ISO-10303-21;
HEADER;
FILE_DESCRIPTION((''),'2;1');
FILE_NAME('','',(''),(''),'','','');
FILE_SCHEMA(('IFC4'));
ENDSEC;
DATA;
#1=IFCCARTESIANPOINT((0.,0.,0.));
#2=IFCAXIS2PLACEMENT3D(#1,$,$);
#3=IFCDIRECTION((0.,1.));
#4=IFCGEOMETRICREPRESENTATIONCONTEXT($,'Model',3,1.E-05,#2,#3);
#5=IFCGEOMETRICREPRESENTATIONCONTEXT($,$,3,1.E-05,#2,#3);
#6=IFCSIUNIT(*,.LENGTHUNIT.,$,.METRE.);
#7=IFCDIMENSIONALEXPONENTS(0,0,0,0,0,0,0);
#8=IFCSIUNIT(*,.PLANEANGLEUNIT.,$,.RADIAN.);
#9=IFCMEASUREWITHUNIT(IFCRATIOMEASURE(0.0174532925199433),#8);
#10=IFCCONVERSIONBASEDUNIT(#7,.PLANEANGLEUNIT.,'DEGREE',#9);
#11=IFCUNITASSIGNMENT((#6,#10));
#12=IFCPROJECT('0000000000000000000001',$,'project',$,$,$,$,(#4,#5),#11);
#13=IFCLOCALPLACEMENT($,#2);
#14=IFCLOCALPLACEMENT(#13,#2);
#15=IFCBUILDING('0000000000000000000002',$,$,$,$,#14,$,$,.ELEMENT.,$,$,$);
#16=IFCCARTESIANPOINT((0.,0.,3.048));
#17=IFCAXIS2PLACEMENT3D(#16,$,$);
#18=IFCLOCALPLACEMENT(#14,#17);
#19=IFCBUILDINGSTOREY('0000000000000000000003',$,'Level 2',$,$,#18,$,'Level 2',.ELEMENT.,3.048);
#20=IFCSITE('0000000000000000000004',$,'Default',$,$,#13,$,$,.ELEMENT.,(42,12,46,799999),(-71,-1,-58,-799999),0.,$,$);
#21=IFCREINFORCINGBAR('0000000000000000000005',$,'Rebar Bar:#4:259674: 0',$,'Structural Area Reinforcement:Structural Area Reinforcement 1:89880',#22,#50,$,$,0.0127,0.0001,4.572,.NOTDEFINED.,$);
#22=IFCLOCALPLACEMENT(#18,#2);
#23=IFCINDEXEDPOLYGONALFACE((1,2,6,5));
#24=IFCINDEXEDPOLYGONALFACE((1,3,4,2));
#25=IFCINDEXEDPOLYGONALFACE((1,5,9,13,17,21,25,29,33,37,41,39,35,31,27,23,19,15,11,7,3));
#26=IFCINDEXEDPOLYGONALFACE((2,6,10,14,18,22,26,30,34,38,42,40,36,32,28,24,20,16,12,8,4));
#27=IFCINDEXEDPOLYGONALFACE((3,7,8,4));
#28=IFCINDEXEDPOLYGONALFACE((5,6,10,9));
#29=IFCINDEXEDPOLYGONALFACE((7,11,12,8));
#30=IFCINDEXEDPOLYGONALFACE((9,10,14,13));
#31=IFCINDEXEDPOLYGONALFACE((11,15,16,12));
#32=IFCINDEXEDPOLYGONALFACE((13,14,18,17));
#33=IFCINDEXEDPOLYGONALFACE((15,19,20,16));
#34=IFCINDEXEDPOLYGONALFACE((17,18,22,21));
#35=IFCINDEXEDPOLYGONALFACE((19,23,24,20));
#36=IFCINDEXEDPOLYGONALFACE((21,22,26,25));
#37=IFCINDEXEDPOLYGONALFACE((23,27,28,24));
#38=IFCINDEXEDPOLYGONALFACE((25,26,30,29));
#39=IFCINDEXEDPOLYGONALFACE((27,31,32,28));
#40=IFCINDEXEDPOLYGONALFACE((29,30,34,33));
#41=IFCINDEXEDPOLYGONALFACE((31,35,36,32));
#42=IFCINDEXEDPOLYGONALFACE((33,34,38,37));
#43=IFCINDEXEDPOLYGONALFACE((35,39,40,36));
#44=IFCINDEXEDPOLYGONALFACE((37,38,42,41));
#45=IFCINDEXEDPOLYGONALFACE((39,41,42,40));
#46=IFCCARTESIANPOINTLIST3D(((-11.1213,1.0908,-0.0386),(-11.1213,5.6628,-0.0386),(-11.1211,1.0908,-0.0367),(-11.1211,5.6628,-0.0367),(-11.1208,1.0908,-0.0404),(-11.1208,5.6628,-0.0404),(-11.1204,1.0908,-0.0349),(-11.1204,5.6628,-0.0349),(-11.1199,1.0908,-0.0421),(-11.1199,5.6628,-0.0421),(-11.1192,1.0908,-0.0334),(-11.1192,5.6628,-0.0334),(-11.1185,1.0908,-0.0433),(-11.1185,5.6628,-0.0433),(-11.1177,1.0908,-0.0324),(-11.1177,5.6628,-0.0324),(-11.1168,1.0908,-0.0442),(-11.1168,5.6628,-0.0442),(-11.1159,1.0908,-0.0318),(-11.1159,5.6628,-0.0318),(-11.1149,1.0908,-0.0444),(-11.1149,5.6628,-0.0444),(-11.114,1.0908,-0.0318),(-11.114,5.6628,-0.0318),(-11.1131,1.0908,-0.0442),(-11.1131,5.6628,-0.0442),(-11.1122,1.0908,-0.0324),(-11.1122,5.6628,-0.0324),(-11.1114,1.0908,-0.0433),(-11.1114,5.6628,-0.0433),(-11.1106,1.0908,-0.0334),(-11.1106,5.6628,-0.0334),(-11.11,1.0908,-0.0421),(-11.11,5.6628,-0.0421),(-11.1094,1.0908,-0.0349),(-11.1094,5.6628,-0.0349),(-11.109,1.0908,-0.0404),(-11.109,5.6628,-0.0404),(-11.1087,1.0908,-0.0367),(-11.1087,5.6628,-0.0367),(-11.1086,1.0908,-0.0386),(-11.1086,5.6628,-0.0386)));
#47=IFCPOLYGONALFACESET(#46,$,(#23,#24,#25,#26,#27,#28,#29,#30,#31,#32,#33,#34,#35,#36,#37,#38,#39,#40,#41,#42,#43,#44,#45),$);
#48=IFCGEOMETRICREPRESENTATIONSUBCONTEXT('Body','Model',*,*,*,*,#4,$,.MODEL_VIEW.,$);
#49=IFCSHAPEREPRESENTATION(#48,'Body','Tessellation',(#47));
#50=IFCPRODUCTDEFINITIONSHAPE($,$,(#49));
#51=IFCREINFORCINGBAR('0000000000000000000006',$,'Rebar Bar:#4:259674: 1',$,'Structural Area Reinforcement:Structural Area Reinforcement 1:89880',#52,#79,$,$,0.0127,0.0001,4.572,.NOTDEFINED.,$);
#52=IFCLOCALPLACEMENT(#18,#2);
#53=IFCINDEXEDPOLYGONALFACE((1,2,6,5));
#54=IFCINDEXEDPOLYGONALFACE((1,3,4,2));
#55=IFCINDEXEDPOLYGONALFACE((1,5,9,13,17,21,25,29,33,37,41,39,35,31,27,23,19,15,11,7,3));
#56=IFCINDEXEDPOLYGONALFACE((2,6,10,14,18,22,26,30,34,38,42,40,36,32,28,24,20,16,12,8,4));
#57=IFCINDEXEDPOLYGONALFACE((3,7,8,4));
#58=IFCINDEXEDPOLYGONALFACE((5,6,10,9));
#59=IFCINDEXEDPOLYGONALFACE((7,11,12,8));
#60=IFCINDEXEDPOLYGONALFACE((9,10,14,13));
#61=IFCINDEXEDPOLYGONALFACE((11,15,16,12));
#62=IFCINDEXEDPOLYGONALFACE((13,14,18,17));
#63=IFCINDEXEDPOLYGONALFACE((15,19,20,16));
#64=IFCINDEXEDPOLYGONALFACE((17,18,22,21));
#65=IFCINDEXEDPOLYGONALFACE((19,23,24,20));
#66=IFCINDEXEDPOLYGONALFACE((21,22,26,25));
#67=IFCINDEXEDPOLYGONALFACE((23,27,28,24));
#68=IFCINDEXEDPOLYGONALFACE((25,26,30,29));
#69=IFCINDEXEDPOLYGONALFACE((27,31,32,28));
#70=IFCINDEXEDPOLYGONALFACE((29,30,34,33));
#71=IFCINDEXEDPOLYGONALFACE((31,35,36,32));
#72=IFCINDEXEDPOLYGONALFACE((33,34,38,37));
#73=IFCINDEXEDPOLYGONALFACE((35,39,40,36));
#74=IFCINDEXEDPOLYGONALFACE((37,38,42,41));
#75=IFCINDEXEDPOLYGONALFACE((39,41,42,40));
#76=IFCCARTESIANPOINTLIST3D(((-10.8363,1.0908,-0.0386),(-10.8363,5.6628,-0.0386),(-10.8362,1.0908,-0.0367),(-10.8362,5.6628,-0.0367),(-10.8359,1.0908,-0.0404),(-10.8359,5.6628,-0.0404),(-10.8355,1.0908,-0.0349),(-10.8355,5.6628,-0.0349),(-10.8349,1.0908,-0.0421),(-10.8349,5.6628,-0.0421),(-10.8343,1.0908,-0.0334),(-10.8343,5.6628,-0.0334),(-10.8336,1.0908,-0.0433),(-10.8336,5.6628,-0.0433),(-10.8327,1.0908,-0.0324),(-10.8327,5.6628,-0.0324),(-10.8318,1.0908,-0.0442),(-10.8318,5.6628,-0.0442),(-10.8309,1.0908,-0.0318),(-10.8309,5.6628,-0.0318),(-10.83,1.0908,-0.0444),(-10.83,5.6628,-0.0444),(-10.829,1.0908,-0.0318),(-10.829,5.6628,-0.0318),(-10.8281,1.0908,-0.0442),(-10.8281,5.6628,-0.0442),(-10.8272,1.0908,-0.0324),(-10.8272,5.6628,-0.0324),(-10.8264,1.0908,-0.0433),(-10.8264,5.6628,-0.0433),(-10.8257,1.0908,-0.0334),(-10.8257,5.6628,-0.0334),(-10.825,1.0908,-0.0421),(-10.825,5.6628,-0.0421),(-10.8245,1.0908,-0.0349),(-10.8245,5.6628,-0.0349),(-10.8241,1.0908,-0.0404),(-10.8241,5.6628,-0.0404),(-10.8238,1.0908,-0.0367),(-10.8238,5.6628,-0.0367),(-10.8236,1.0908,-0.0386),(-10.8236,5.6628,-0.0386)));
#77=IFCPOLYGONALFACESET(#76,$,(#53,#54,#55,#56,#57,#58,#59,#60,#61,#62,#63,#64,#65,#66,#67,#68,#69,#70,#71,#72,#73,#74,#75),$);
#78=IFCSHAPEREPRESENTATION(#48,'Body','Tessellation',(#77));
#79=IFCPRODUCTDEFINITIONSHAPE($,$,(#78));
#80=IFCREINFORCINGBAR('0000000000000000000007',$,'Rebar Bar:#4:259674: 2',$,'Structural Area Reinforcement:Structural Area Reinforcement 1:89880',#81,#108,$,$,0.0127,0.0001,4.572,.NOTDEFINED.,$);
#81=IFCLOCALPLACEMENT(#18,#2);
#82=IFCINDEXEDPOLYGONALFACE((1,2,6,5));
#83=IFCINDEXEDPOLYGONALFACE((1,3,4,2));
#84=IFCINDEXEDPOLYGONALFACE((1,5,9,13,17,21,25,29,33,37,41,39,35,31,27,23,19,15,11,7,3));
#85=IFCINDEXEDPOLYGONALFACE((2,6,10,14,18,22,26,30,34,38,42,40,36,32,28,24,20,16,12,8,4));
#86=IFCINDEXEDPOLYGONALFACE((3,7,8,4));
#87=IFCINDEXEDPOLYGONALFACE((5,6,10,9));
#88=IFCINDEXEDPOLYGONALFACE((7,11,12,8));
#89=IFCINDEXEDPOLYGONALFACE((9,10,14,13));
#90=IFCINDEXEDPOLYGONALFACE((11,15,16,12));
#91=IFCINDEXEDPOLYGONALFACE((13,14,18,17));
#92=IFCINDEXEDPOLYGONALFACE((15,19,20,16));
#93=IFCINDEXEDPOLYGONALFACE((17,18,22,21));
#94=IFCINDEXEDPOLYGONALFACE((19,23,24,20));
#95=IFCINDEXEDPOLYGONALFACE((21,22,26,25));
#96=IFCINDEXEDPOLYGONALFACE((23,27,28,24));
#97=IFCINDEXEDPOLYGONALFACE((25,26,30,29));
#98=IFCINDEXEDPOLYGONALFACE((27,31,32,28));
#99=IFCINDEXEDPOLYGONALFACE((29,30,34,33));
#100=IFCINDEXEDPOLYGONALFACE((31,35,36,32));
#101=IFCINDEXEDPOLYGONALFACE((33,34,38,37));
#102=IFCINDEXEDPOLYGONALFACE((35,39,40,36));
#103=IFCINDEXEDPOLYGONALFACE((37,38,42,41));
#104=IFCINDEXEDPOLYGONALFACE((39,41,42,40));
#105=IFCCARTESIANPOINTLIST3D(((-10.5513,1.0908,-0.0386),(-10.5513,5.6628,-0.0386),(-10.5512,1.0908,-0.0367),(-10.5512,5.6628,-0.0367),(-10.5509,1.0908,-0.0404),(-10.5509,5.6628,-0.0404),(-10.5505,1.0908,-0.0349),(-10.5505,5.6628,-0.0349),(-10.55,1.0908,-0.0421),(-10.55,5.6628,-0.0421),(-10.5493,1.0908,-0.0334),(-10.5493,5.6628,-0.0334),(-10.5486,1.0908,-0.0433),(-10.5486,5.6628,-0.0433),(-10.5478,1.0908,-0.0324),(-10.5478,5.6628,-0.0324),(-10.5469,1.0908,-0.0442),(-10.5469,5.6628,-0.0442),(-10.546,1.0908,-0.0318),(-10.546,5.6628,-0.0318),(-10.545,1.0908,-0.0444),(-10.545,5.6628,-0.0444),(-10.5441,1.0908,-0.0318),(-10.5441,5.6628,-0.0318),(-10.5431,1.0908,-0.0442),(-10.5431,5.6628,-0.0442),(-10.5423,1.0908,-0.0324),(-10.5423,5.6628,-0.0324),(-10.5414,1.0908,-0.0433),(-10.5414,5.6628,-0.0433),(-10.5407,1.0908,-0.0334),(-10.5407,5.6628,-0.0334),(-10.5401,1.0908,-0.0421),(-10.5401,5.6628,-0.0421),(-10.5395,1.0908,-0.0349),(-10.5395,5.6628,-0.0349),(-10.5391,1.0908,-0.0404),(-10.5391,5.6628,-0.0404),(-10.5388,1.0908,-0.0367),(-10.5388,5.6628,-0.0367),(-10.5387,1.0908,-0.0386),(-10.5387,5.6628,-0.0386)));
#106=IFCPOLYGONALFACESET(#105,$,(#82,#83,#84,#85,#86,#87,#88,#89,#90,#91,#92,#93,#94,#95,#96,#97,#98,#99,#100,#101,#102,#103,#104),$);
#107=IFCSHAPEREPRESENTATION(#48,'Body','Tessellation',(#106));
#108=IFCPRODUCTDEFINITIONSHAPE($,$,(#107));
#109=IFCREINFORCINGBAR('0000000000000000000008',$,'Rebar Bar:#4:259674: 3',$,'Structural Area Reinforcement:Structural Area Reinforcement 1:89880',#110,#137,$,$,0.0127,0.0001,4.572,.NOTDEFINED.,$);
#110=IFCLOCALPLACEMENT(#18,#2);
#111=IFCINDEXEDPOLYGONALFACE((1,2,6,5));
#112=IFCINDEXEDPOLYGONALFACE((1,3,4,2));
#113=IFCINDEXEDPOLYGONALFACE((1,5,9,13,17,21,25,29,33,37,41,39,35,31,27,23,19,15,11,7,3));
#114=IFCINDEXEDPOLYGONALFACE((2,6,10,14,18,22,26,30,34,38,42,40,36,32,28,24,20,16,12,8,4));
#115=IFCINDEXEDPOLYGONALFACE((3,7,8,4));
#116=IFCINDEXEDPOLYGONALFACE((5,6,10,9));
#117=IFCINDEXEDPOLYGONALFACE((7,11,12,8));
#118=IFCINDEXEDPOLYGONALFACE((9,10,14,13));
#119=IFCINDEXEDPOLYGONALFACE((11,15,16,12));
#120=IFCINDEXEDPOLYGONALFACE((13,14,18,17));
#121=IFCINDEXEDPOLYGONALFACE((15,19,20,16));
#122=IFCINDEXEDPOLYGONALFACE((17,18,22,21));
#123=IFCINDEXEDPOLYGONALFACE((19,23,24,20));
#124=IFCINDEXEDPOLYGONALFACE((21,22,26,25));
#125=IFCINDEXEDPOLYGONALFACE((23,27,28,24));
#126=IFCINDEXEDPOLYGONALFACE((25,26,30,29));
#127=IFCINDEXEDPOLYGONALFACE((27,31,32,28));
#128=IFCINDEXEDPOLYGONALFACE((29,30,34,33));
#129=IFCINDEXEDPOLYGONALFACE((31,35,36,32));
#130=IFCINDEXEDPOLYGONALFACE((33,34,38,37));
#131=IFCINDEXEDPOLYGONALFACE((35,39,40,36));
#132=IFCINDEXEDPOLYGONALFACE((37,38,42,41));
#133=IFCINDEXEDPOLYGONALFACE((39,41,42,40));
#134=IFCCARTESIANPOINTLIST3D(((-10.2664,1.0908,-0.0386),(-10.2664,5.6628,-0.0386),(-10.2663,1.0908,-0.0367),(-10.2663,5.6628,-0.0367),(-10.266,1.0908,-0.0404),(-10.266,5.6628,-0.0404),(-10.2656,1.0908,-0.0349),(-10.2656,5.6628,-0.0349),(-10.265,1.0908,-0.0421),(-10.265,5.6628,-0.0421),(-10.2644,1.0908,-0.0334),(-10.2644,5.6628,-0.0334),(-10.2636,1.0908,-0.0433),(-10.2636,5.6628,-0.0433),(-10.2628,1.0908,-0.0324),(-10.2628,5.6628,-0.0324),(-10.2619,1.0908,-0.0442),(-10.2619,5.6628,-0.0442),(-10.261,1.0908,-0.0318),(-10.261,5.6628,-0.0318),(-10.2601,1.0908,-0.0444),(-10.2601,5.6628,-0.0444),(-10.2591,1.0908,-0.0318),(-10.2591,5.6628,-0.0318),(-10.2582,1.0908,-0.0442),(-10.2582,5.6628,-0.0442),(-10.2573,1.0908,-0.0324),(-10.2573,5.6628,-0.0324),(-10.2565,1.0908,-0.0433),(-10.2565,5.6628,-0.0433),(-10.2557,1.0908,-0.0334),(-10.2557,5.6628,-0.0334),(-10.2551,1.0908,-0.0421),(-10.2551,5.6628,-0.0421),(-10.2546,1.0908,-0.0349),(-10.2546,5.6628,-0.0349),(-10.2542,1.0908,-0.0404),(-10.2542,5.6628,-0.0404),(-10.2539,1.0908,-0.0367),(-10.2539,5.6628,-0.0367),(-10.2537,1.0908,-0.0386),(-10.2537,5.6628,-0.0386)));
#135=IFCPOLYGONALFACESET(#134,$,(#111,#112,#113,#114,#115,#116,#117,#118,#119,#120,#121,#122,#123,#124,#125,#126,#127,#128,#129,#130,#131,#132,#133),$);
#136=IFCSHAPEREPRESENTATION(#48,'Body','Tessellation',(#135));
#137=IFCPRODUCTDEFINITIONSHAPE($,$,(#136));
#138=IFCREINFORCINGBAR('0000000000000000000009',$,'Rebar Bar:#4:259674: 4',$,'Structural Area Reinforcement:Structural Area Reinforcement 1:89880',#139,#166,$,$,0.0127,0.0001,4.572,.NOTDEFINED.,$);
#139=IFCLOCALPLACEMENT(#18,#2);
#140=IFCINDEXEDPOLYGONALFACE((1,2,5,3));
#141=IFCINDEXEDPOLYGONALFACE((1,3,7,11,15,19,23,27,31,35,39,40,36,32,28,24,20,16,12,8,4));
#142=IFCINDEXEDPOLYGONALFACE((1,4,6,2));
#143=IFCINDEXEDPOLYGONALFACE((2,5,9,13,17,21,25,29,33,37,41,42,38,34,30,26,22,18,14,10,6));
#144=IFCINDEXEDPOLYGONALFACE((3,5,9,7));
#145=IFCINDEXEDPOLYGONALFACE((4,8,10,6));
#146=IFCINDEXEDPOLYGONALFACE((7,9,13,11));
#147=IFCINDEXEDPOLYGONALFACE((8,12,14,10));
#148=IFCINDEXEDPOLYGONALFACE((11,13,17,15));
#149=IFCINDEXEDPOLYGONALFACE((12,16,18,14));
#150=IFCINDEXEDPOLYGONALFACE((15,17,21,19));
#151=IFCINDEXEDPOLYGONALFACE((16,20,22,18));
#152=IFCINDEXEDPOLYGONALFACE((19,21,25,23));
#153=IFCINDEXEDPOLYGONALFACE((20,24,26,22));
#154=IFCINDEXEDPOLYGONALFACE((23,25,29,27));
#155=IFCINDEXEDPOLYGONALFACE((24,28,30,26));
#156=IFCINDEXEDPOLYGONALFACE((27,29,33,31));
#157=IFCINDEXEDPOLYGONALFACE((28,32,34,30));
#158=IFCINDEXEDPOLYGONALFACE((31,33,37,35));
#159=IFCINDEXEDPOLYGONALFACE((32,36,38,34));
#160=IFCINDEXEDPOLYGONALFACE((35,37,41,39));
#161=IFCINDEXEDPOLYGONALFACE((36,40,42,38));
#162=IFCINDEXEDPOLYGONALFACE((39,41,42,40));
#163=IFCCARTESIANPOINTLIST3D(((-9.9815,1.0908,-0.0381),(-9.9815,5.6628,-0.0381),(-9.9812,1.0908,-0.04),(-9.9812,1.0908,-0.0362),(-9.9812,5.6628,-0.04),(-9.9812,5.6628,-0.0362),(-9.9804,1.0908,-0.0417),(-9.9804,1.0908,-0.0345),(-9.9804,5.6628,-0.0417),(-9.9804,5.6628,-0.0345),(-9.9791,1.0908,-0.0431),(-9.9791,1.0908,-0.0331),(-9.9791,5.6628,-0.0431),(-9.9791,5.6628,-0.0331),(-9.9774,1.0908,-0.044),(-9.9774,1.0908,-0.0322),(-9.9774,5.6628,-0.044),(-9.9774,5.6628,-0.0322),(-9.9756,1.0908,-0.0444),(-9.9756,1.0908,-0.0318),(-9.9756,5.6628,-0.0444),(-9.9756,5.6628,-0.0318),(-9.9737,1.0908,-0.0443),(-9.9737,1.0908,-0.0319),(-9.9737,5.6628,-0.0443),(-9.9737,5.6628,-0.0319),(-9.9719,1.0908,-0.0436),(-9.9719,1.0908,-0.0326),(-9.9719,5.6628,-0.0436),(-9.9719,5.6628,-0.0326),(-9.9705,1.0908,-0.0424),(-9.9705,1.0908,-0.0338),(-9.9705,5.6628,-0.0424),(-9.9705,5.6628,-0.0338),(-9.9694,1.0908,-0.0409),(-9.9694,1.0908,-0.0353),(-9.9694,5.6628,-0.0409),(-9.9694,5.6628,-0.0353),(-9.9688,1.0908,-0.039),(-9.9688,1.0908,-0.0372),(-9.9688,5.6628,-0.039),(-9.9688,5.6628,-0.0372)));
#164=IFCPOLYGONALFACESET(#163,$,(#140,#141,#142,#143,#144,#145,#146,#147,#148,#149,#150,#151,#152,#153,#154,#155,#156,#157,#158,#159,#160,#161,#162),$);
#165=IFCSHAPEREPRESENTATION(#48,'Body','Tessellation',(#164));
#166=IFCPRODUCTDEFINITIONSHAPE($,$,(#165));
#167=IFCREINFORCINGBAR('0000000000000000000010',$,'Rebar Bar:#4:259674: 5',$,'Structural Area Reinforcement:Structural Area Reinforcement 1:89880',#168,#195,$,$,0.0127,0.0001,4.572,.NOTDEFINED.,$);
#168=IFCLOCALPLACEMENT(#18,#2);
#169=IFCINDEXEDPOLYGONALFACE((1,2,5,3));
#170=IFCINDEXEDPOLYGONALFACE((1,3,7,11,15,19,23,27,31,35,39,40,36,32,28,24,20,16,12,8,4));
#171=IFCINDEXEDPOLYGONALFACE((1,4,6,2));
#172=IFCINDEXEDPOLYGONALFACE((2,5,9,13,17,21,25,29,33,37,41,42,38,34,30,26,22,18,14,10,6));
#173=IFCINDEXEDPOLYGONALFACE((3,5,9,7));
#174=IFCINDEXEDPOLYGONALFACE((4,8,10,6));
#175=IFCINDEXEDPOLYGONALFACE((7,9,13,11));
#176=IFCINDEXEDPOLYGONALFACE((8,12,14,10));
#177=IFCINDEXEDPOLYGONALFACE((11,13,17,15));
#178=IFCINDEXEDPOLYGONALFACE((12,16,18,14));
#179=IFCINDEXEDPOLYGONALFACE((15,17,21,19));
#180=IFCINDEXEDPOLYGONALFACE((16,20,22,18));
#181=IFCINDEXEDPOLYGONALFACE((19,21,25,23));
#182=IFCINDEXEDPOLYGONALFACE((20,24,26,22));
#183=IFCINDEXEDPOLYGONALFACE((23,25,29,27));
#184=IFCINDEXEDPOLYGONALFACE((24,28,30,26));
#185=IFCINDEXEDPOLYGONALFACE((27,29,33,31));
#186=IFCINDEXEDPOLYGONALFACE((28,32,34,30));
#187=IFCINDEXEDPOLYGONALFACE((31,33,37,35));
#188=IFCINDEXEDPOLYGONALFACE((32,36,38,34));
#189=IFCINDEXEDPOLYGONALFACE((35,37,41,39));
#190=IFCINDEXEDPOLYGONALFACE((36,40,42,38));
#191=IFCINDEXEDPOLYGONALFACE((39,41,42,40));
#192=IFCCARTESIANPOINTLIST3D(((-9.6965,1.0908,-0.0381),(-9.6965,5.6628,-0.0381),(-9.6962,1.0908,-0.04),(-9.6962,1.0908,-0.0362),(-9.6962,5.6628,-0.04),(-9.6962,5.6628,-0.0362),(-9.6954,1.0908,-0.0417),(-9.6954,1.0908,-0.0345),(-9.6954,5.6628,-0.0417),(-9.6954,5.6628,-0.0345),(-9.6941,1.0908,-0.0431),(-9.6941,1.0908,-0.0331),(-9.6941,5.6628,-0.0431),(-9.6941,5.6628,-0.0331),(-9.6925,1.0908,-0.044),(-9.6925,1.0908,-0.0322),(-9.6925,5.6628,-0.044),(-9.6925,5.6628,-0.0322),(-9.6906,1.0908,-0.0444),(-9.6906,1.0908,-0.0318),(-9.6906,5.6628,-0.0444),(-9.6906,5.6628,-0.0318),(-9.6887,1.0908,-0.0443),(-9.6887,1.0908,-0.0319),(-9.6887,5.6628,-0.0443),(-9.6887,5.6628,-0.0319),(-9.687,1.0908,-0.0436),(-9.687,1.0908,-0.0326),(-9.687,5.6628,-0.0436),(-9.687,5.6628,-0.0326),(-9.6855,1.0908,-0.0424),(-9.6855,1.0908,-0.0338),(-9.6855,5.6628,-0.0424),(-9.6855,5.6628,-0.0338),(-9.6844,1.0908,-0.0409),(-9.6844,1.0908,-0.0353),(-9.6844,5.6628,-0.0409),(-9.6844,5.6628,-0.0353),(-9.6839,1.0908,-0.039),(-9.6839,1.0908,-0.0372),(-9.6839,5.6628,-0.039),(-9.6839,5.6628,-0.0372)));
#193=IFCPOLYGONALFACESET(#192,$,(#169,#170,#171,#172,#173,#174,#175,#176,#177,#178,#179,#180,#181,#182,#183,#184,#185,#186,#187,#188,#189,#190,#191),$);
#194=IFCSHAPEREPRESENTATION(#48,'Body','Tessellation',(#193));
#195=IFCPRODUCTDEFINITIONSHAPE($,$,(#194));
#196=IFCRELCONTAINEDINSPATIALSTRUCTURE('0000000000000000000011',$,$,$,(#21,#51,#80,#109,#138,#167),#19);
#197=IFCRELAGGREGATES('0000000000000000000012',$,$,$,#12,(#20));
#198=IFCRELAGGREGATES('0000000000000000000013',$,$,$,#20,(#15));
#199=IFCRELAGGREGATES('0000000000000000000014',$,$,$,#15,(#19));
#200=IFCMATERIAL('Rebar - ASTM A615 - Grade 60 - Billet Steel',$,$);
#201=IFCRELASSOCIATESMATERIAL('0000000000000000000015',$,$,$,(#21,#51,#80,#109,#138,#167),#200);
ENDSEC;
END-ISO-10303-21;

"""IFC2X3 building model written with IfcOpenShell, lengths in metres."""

from ifc_helpers import new_model, entity, si_unit, converted_unit, direction, frame, origin, place, context, subcontext, project, spatial, material, element, save


model = new_model("IFC2X3")

# Units and contexts
model_context = context("Model", 3, precision=1e-05, world=origin(), true_north=direction((0.0, 1.0)))
context_of_model = context(None, 3, precision=1e-05, world=origin(), true_north=direction((0.0, 1.0)))
body_context = subcontext(model_context, "Body", "Model", "MODEL_VIEW")
ifc_project = project(units=[si_unit("LENGTHUNIT", "METRE"), converted_unit("PLANEANGLEUNIT", "DEGREE", entity("IfcRatioMeasure", 0.0174532925199433), si_unit("PLANEANGLEUNIT", "RADIAN"), dimensions=[0, 0, 0, 0, 0, 0, 0])], contexts=[model_context, context_of_model])

# Site, building, storey
site_placement = place(None, origin())
site = spatial("IfcSite", under=ifc_project, at=site_placement, Name="Default", CompositionType="ELEMENT", RefLatitude=(42, 12, 46, 799999), RefLongitude=(-71, -1, -58, -799999), RefElevation=0.0)
building_placement = place(site_placement, origin())
building = spatial("IfcBuilding", under=site, at=building_placement, CompositionType="ELEMENT")
storey_placement = place(building_placement, frame((0.0, 0.0, 3.048)))
storey = spatial("IfcBuildingStorey", under=building, at=storey_placement, Name="Level 2", LongName="Level 2", CompositionType="ELEMENT", Elevation=3.048)

# Reinforcing bars
ifc_material_1 = material(Name="Rebar - ASTM A615 - Grade 60 - Billet Steel")
reinforcing_bar_1_placement = place(storey_placement, origin())
element("IfcReinforcingBar", 1, at=reinforcing_bar_1_placement, inside=storey, material=ifc_material_1, Name="Rebar Bar:#4:259674: 0", ObjectType="Structural Area Reinforcement:Structural Area Reinforcement 1:89880", BarLength=4.572, BarRole="NOTDEFINED", CrossSectionArea=0.0001, NominalDiameter=0.0127, context=body_context, shape_type="AdvancedSweptSolid", body=[
    entity("IfcSweptDiskSolid", entity("IfcCompositeCurve", [entity("IfcCompositeCurveSegment", "CONTINUOUS", True, entity("IfcPolyline", [entity("IfcCartesianPoint", [-11.1149, 5.6628, -0.0381]), entity("IfcCartesianPoint", [-11.1149, 1.0908, -0.0381])]))], False), 0.0063, None, 0.0, 1.0),
])
reinforcing_bar_2_placement = place(storey_placement, origin())
element("IfcReinforcingBar", 2, at=reinforcing_bar_2_placement, inside=storey, material=ifc_material_1, Name="Rebar Bar:#4:259674: 1", ObjectType="Structural Area Reinforcement:Structural Area Reinforcement 1:89880", BarLength=4.572, BarRole="NOTDEFINED", CrossSectionArea=0.0001, NominalDiameter=0.0127, context=body_context, shape_type="AdvancedSweptSolid", body=[
    entity("IfcSweptDiskSolid", entity("IfcCompositeCurve", [entity("IfcCompositeCurveSegment", "CONTINUOUS", True, entity("IfcPolyline", [entity("IfcCartesianPoint", [-10.83, 5.6628, -0.0381]), entity("IfcCartesianPoint", [-10.83, 1.0908, -0.0381])]))], False), 0.0063, None, 0.0, 1.0),
])
reinforcing_bar_3_placement = place(storey_placement, origin())
element("IfcReinforcingBar", 3, at=reinforcing_bar_3_placement, inside=storey, material=ifc_material_1, Name="Rebar Bar:#4:259674: 2", ObjectType="Structural Area Reinforcement:Structural Area Reinforcement 1:89880", BarLength=4.572, BarRole="NOTDEFINED", CrossSectionArea=0.0001, NominalDiameter=0.0127, context=body_context, shape_type="AdvancedSweptSolid", body=[
    entity("IfcSweptDiskSolid", entity("IfcCompositeCurve", [entity("IfcCompositeCurveSegment", "CONTINUOUS", True, entity("IfcPolyline", [entity("IfcCartesianPoint", [-10.545, 5.6628, -0.0381]), entity("IfcCartesianPoint", [-10.545, 1.0908, -0.0381])]))], False), 0.0063, None, 0.0, 1.0),
])
reinforcing_bar_4_placement = place(storey_placement, origin())
element("IfcReinforcingBar", 4, at=reinforcing_bar_4_placement, inside=storey, material=ifc_material_1, Name="Rebar Bar:#4:259674: 3", ObjectType="Structural Area Reinforcement:Structural Area Reinforcement 1:89880", BarLength=4.572, BarRole="NOTDEFINED", CrossSectionArea=0.0001, NominalDiameter=0.0127, context=body_context, shape_type="AdvancedSweptSolid", body=[
    entity("IfcSweptDiskSolid", entity("IfcCompositeCurve", [entity("IfcCompositeCurveSegment", "CONTINUOUS", True, entity("IfcPolyline", [entity("IfcCartesianPoint", [-10.2601, 5.6628, -0.0381]), entity("IfcCartesianPoint", [-10.2601, 1.0908, -0.0381])]))], False), 0.0063, None, 0.0, 1.0),
])
reinforcing_bar_5_placement = place(storey_placement, origin())
element("IfcReinforcingBar", 5, at=reinforcing_bar_5_placement, inside=storey, material=ifc_material_1, Name="Rebar Bar:#4:259674: 4", ObjectType="Structural Area Reinforcement:Structural Area Reinforcement 1:89880", BarLength=4.572, BarRole="NOTDEFINED", CrossSectionArea=0.0001, NominalDiameter=0.0127, context=body_context, shape_type="AdvancedSweptSolid", body=[
    entity("IfcSweptDiskSolid", entity("IfcCompositeCurve", [entity("IfcCompositeCurveSegment", "CONTINUOUS", True, entity("IfcPolyline", [entity("IfcCartesianPoint", [-9.9751, 5.6628, -0.0381]), entity("IfcCartesianPoint", [-9.9751, 1.0908, -0.0381])]))], False), 0.0063, None, 0.0, 1.0),
])
reinforcing_bar_6_placement = place(storey_placement, origin())
element("IfcReinforcingBar", 6, at=reinforcing_bar_6_placement, inside=storey, material=ifc_material_1, Name="Rebar Bar:#4:259674: 5", ObjectType="Structural Area Reinforcement:Structural Area Reinforcement 1:89880", BarLength=4.572, BarRole="NOTDEFINED", CrossSectionArea=0.0001, NominalDiameter=0.0127, context=body_context, shape_type="AdvancedSweptSolid", body=[
    entity("IfcSweptDiskSolid", entity("IfcCompositeCurve", [entity("IfcCompositeCurveSegment", "CONTINUOUS", True, entity("IfcPolyline", [entity("IfcCartesianPoint", [-9.6901, 5.6628, -0.0381]), entity("IfcCartesianPoint", [-9.6901, 1.0908, -0.0381])]))], False), 0.0063, None, 0.0, 1.0),
])

save(model, "model.ifc")
